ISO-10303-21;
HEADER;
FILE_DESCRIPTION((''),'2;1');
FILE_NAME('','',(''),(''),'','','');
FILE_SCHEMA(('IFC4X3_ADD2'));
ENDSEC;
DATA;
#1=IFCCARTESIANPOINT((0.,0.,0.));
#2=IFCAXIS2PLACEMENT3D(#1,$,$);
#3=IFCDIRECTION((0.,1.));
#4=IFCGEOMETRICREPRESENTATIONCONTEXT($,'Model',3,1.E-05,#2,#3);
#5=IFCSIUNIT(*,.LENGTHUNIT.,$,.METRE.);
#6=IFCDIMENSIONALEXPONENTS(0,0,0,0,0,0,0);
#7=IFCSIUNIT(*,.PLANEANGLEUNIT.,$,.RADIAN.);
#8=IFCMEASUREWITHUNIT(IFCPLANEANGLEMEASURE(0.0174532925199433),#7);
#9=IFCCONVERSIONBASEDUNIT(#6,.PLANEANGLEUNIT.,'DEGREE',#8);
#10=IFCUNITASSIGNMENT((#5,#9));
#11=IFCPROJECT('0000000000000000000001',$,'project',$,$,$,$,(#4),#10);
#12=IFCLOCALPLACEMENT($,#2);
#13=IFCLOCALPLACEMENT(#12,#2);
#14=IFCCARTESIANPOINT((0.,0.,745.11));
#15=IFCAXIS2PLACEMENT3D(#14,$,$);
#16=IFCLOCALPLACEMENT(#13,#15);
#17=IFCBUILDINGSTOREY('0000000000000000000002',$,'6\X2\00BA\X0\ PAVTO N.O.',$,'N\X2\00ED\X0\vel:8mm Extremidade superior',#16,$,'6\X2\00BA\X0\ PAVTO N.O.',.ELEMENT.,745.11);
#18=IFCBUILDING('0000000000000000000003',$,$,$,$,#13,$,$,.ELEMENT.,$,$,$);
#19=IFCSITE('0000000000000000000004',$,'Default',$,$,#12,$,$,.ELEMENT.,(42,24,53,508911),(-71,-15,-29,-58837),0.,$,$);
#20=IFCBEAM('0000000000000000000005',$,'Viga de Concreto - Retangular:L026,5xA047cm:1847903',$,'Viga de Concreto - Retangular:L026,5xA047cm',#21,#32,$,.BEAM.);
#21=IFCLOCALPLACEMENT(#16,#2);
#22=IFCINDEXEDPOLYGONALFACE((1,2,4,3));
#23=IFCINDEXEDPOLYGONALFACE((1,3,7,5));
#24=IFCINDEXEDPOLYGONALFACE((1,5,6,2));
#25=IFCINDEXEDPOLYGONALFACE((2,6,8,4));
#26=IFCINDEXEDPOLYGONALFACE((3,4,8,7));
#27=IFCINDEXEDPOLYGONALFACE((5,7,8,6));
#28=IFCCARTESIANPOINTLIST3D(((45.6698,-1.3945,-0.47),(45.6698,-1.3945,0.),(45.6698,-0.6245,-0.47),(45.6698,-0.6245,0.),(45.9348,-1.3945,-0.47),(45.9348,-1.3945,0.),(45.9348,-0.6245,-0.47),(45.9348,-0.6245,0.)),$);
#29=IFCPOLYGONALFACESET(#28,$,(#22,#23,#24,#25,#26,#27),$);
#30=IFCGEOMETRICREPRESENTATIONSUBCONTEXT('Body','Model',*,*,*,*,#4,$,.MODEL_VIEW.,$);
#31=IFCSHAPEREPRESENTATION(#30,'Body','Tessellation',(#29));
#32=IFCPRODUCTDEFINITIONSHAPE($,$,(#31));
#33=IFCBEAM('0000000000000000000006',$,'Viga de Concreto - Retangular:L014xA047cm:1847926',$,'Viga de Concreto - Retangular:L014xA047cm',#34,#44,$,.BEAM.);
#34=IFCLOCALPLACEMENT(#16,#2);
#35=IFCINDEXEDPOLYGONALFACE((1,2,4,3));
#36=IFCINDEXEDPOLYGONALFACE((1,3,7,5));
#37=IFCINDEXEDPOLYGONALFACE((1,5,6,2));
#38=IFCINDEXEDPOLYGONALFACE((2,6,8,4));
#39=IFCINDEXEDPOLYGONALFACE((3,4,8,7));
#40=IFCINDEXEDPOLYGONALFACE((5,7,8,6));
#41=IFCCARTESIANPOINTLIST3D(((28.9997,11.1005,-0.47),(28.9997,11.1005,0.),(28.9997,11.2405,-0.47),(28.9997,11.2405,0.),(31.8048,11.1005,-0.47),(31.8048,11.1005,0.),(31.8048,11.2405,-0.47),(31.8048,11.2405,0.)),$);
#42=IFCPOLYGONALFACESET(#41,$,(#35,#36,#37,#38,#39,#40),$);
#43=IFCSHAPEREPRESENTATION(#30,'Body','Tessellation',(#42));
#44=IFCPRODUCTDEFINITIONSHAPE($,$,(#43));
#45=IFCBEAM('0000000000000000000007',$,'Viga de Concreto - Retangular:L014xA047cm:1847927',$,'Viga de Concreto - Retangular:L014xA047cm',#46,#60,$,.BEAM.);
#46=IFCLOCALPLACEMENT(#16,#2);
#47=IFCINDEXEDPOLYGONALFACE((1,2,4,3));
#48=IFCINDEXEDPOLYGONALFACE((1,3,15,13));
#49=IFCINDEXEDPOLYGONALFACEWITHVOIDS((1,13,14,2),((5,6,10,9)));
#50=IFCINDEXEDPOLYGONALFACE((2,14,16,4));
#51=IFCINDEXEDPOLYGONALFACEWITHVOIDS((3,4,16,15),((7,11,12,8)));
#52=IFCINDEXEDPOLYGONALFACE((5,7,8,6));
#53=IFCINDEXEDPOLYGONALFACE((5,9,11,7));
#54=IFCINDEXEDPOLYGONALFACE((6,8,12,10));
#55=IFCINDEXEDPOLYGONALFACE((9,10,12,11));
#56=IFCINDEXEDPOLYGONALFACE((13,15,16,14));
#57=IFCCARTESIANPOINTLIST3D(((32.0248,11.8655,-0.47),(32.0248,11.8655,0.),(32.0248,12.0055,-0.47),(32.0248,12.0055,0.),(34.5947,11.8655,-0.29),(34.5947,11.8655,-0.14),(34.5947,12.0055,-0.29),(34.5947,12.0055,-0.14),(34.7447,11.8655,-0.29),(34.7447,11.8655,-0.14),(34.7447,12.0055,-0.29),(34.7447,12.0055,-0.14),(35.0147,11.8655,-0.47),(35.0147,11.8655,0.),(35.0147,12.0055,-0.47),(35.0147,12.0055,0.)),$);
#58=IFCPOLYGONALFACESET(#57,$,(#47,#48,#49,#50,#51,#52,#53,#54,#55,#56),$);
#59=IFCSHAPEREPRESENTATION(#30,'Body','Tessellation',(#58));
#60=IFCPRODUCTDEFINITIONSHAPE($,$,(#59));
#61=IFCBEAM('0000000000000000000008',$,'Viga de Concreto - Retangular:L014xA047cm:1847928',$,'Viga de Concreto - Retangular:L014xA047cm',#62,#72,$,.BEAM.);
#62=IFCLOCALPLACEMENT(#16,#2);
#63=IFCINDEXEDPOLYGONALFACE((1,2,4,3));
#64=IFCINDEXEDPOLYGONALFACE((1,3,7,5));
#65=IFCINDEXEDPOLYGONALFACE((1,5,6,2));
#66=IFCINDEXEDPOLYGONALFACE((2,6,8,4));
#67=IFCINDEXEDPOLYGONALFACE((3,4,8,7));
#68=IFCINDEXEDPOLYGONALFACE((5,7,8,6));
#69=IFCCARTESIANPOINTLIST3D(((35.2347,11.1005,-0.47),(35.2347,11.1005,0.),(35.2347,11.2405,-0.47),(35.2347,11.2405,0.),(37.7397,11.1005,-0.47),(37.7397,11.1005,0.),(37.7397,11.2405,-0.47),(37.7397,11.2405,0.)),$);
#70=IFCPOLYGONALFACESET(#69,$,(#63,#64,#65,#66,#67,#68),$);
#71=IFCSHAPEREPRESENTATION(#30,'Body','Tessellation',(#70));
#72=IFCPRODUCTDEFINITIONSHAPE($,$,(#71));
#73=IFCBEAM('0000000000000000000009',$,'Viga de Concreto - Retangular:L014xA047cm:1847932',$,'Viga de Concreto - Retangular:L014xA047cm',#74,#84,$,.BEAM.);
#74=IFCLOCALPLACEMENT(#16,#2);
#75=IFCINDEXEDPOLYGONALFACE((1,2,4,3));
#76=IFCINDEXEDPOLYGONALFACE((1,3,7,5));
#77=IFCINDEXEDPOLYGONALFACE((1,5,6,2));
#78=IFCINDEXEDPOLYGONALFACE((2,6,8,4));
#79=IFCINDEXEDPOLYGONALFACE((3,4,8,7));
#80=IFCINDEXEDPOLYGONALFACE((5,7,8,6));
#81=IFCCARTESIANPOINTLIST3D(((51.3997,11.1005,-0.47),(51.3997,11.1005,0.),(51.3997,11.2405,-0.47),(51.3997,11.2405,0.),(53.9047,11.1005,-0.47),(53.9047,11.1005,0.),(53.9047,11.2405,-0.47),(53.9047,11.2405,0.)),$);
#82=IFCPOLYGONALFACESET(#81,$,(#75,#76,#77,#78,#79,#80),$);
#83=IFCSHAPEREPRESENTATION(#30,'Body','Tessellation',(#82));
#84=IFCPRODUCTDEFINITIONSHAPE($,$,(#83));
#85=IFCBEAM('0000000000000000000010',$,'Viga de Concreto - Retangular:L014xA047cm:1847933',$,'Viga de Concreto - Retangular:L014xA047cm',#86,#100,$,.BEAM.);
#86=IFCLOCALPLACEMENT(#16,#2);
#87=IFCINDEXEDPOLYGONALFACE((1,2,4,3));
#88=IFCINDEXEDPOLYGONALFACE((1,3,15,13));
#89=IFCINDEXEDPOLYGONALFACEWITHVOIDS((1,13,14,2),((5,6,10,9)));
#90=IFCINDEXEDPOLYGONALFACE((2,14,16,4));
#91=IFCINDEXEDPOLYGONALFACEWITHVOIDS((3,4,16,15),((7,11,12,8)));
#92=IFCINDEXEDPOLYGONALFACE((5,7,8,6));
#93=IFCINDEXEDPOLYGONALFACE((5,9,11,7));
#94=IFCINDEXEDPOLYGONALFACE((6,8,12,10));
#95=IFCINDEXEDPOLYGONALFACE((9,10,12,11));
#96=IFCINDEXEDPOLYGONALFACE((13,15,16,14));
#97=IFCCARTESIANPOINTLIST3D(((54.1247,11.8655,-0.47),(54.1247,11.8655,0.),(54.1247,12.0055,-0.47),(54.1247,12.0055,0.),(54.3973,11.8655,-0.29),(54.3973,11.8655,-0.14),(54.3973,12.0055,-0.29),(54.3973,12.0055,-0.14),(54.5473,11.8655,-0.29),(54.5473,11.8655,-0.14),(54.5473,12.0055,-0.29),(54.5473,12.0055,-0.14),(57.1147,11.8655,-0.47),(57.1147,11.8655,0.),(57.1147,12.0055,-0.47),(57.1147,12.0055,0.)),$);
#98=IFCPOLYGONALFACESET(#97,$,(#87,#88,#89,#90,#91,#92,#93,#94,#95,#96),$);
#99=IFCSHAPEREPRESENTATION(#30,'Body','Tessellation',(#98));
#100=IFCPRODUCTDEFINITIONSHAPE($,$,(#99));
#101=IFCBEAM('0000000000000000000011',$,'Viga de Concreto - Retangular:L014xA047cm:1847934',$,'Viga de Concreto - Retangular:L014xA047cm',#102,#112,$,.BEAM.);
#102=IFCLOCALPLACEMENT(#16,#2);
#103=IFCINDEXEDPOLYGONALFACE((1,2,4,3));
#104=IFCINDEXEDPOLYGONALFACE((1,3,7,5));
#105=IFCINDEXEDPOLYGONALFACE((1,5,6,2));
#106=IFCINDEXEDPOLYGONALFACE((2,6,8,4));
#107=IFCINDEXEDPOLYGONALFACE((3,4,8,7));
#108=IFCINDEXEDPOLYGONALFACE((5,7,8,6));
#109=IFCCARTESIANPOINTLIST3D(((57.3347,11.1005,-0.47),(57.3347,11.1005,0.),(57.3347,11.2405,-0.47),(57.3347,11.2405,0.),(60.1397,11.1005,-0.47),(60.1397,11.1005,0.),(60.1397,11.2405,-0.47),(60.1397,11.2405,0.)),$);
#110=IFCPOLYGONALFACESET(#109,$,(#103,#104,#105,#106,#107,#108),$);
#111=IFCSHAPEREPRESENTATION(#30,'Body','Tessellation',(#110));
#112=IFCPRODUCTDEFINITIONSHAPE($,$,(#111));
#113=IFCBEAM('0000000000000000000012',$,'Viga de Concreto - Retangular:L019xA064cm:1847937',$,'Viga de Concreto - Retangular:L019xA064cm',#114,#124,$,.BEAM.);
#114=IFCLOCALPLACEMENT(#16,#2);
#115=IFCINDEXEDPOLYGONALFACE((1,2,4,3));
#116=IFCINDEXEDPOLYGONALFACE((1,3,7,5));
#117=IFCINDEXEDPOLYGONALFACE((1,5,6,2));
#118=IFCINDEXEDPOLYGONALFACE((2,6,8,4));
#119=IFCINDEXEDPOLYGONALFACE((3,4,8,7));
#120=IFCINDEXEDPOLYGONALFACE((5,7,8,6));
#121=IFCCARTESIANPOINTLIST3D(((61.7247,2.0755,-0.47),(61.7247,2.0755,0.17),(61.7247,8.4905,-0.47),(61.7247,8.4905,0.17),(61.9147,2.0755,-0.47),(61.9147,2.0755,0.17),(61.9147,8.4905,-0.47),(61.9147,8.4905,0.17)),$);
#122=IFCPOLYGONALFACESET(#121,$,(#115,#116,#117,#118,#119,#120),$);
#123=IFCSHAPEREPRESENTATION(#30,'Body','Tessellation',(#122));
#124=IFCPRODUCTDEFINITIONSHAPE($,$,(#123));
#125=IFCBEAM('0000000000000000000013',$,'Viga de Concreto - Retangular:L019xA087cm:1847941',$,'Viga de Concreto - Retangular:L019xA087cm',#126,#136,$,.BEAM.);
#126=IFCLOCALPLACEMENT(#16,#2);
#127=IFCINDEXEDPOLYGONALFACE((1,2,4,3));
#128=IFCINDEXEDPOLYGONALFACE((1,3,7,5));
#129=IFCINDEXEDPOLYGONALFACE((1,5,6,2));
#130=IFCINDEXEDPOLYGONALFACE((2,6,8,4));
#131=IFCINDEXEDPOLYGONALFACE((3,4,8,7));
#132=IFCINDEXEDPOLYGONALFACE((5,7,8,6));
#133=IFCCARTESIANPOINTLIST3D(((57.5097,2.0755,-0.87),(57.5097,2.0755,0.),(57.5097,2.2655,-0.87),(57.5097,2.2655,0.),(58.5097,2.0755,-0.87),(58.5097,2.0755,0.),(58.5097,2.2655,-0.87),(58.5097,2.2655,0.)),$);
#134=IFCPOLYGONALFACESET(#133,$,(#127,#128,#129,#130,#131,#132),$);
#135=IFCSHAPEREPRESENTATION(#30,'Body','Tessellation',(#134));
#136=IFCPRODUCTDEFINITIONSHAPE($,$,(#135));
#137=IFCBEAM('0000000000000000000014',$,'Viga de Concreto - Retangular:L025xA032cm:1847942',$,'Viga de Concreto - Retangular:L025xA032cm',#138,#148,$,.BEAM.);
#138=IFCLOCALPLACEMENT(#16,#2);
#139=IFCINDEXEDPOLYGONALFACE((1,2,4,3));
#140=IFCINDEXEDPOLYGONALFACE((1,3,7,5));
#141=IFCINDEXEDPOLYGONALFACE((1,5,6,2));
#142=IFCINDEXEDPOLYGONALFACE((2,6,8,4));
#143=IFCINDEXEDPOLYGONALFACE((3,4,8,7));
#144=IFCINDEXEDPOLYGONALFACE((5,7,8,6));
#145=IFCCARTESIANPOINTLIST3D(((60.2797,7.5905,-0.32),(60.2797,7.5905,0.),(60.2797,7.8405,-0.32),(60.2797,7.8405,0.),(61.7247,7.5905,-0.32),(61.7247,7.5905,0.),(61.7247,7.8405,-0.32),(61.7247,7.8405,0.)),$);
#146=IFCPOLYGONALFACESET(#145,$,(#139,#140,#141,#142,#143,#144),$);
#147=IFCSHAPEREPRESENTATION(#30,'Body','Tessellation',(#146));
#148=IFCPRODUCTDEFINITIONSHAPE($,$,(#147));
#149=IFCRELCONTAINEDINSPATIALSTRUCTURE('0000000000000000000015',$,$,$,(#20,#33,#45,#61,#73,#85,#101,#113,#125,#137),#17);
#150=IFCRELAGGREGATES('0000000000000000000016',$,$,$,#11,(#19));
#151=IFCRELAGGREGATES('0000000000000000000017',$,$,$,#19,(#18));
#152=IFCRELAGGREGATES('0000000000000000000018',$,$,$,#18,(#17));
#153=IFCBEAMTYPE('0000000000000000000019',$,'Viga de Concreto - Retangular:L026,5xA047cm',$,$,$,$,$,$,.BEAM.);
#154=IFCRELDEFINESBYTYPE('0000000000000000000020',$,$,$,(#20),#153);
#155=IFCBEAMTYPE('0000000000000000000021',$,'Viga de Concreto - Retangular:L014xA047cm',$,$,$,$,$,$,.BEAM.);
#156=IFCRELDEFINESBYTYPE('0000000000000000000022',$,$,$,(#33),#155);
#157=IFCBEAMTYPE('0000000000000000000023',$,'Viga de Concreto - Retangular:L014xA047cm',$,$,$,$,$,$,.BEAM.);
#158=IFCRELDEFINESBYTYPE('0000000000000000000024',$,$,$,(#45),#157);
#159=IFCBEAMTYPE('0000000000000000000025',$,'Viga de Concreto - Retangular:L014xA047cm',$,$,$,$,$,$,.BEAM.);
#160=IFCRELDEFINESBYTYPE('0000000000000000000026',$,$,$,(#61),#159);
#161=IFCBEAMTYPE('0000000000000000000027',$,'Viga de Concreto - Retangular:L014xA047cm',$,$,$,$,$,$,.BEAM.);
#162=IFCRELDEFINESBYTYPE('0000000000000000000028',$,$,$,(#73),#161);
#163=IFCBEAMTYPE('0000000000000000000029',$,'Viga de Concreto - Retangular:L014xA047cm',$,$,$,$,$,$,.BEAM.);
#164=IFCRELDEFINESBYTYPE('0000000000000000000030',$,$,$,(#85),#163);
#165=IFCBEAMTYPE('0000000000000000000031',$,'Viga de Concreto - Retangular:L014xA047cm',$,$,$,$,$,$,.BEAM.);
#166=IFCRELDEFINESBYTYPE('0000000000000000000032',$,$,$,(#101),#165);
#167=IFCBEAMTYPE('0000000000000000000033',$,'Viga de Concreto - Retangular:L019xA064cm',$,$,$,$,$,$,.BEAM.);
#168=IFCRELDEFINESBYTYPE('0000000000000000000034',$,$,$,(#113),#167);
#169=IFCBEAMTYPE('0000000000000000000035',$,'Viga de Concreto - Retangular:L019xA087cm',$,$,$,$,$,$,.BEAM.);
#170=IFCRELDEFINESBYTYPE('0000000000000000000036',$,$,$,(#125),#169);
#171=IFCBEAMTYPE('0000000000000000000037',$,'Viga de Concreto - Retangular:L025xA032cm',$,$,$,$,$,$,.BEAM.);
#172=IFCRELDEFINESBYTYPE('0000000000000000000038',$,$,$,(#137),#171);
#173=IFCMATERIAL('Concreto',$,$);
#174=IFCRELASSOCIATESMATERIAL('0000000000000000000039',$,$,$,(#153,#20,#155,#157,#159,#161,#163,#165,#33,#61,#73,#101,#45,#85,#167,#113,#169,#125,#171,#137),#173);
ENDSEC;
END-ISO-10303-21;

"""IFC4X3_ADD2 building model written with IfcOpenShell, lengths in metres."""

from ifc_helpers import new_model, entity, si_unit, converted_unit, direction, frame, frame_2d, origin, origin_2d_with_axis, place, context, subcontext, project, spatial, rectangle, extrude, boolean, source, transform, mapped, material, material_profile, profile_set, profile_usage, type_object, type_shapes, element, save


model = new_model("IFC4X3_ADD2")

# Units and contexts
model_context = context("Model", 3, precision=1e-05, world=origin(), true_north=direction((0.0, 1.0)))
body_context = subcontext(model_context, "Body", "Model", "MODEL_VIEW")
ifc_project = project(units=[si_unit("LENGTHUNIT", "METRE"), converted_unit("PLANEANGLEUNIT", "DEGREE", entity("IfcPlaneAngleMeasure", 0.0174532925199433), si_unit("PLANEANGLEUNIT", "RADIAN"), dimensions=[0, 0, 0, 0, 0, 0, 0])], contexts=[model_context])

# Site, building, storey
site_placement = place(None, origin())
site = spatial("IfcSite", under=ifc_project, at=site_placement, Name="Default", CompositionType="ELEMENT", RefLatitude=(42, 24, 53, 508911), RefLongitude=(-71, -15, -29, -58837), RefElevation=0.0)
building_placement = place(site_placement, origin())
building = spatial("IfcBuilding", under=site, at=building_placement, CompositionType="ELEMENT")
storey_placement = place(building_placement, frame((0.0, 0.0, 745.11)))
storey = spatial("IfcBuildingStorey", under=building, at=storey_placement, Name="6º PAVTO N.O.", ObjectType="Nível:8mm Extremidade superior", LongName="6º PAVTO N.O.", CompositionType="ELEMENT", Elevation=745.11)

# Beams
ifc_material = material(Name="Concreto")
ifc_material_profile_1 = material_profile(ifc_material, rectangle(XDim=0.47, YDim=0.265, at=frame_2d((0.0, 0.0), x_axis=(0.0, 1.0))), Name="L026,5xA047cm")
ifc_profile_set_1 = profile_set([ifc_material_profile_1], Name="L026,5xA047cm")
ifc_profile_usage_1 = profile_usage(ifc_profile_set_1, cardinal=8)
beam_type_1 = type_object("IfcBeamType", Name="Viga de Concreto - Retangular:L026,5xA047cm", PredefinedType="BEAM", material=ifc_profile_set_1)
shared_shape_1 = source(origin(), body_context, "Body", "SweptSolid", [
    extrude(rectangle(XDim=0.47, YDim=0.265, at=frame_2d((0.0, 0.0), x_axis=(0.0, 1.0))), frame((45.8023, -0.6245, 744.875), z_axis=(0.0, -1.0, 0.0), x_axis=(-1.0, 0.0, 0.0)), (0.0, 0.0, 1.0), 0.77),
])
type_shapes(beam_type_1, [shared_shape_1])
beam_1_placement = place(storey_placement, frame((0.0, 0.0, -745.11)))
element("IfcBeam", 1, at=beam_1_placement, inside=storey, type_object=beam_type_1, material=ifc_profile_usage_1, Name="Viga de Concreto - Retangular:L026,5xA047cm:1847903", ObjectType="Viga de Concreto - Retangular:L026,5xA047cm", PredefinedType="BEAM", context=body_context, shape_type="MappedRepresentation", body=[
    mapped(shared_shape_1, transform((0.0, 0.0, 0.0), scale=1.0)),
])
ifc_material_profile_2 = material_profile(ifc_material, rectangle(XDim=0.47, YDim=0.14, at=frame_2d((0.0, 0.0), x_axis=(0.0, 1.0))), Name="L014xA047cm")
ifc_profile_set_2 = profile_set([ifc_material_profile_2], Name="L014xA047cm")
ifc_profile_usage_2 = profile_usage(ifc_profile_set_2, cardinal=8)
beam_type_2 = type_object("IfcBeamType", Name="Viga de Concreto - Retangular:L014xA047cm", PredefinedType="BEAM", material=ifc_profile_set_2)
shared_shape_2 = source(origin(), body_context, "Body", "SweptSolid", [
    extrude(rectangle(XDim=0.47, YDim=0.14, at=origin_2d_with_axis()), frame((31.8048, 11.1705, 744.875), z_axis=(-1.0, 0.0, 0.0), x_axis=(0.0, 0.0, -1.0)), (0.0, 0.0, 1.0), 2.8051),
])
type_shapes(beam_type_2, [shared_shape_2])
beam_2_placement = place(storey_placement, frame((0.0, 0.0, -745.11)))
element("IfcBeam", 2, at=beam_2_placement, inside=storey, type_object=beam_type_2, material=ifc_profile_usage_2, Name="Viga de Concreto - Retangular:L014xA047cm:1847926", ObjectType="Viga de Concreto - Retangular:L014xA047cm", PredefinedType="BEAM", context=body_context, shape_type="MappedRepresentation", body=[
    mapped(shared_shape_2, transform((0.0, 0.0, 0.0), scale=1.0)),
])
beam_type_3 = type_object("IfcBeamType", Name="Viga de Concreto - Retangular:L014xA047cm", PredefinedType="BEAM", material=ifc_profile_set_2)
shared_shape_3 = source(origin(), body_context, "Body", "CSG", [
    boolean("DIFFERENCE", extrude(rectangle(XDim=0.47, YDim=0.14, at=frame_2d((0.0, 0.0), x_axis=(0.0, 1.0))), frame((32.0248, 11.9355, 744.875), z_axis=(1.0, 0.0, 0.0), x_axis=(0.0, 1.0, 0.0)), (0.0, 0.0, 1.0), 2.9899), extrude(rectangle(XDim=0.15, YDim=0.15, at=frame_2d((0.0, 0.0), x_axis=(0.0, 1.0))), frame((34.6697, 11.8655, 744.895), z_axis=(0.0, 1.0, 0.0), x_axis=(1.0, 0.0, 0.0)), (0.0, 0.0, 1.0), 0.14)),
])
type_shapes(beam_type_3, [shared_shape_3])
beam_3_placement = place(storey_placement, frame((0.0, 0.0, -745.11)))
element("IfcBeam", 3, at=beam_3_placement, inside=storey, type_object=beam_type_3, material=ifc_material, Name="Viga de Concreto - Retangular:L014xA047cm:1847927", ObjectType="Viga de Concreto - Retangular:L014xA047cm", PredefinedType="BEAM", context=body_context, shape_type="MappedRepresentation", body=[
    mapped(shared_shape_3, transform((0.0, 0.0, 0.0), scale=1.0)),
])
beam_type_4 = type_object("IfcBeamType", Name="Viga de Concreto - Retangular:L014xA047cm", PredefinedType="BEAM", material=ifc_profile_set_2)
shared_shape_4 = source(origin(), body_context, "Body", "SweptSolid", [
    extrude(rectangle(XDim=0.47, YDim=0.14, at=origin_2d_with_axis()), frame((35.2347, 11.1705, 744.875), z_axis=(1.0, 0.0, 0.0), x_axis=(0.0, 0.0, -1.0)), (0.0, 0.0, 1.0), 2.505),
])
type_shapes(beam_type_4, [shared_shape_4])
beam_4_placement = place(storey_placement, frame((0.0, 0.0, -745.11)))
element("IfcBeam", 4, at=beam_4_placement, inside=storey, type_object=beam_type_4, material=ifc_profile_usage_2, Name="Viga de Concreto - Retangular:L014xA047cm:1847928", ObjectType="Viga de Concreto - Retangular:L014xA047cm", PredefinedType="BEAM", context=body_context, shape_type="MappedRepresentation", body=[
    mapped(shared_shape_4, transform((0.0, 0.0, 0.0), scale=1.0)),
])
beam_type_5 = type_object("IfcBeamType", Name="Viga de Concreto - Retangular:L014xA047cm", PredefinedType="BEAM", material=ifc_profile_set_2)
shared_shape_5 = source(origin(), body_context, "Body", "SweptSolid", [
    extrude(rectangle(XDim=0.47, YDim=0.14, at=origin_2d_with_axis()), frame((51.3997, 11.1705, 744.875), z_axis=(1.0, 0.0, 0.0), x_axis=(0.0, 0.0, -1.0)), (0.0, 0.0, 1.0), 2.505),
])
type_shapes(beam_type_5, [shared_shape_5])
beam_5_placement = place(storey_placement, frame((0.0, 0.0, -745.11)))
element("IfcBeam", 5, at=beam_5_placement, inside=storey, type_object=beam_type_5, material=ifc_profile_usage_2, Name="Viga de Concreto - Retangular:L014xA047cm:1847932", ObjectType="Viga de Concreto - Retangular:L014xA047cm", PredefinedType="BEAM", context=body_context, shape_type="MappedRepresentation", body=[
    mapped(shared_shape_5, transform((0.0, 0.0, 0.0), scale=1.0)),
])
beam_type_6 = type_object("IfcBeamType", Name="Viga de Concreto - Retangular:L014xA047cm", PredefinedType="BEAM", material=ifc_profile_set_2)
shared_shape_6 = source(origin(), body_context, "Body", "CSG", [
    boolean("DIFFERENCE", extrude(rectangle(XDim=0.47, YDim=0.14, at=frame_2d((0.0, 0.0), x_axis=(0.0, 1.0))), frame((54.1247, 11.9355, 744.875), z_axis=(1.0, 0.0, 0.0), x_axis=(0.0, 1.0, 0.0)), (0.0, 0.0, 1.0), 2.99), extrude(rectangle(XDim=0.15, YDim=0.15, at=frame_2d((0.0, 0.0), x_axis=(0.0, 1.0))), frame((54.4723, 11.8655, 744.895), z_axis=(0.0, 1.0, 0.0), x_axis=(1.0, 0.0, 0.0)), (0.0, 0.0, 1.0), 0.14)),
])
type_shapes(beam_type_6, [shared_shape_6])
beam_6_placement = place(storey_placement, frame((0.0, 0.0, -745.11)))
element("IfcBeam", 6, at=beam_6_placement, inside=storey, type_object=beam_type_6, material=ifc_material, Name="Viga de Concreto - Retangular:L014xA047cm:1847933", ObjectType="Viga de Concreto - Retangular:L014xA047cm", PredefinedType="BEAM", context=body_context, shape_type="MappedRepresentation", body=[
    mapped(shared_shape_6, transform((0.0, 0.0, 0.0), scale=1.0)),
])
beam_type_7 = type_object("IfcBeamType", Name="Viga de Concreto - Retangular:L014xA047cm", PredefinedType="BEAM", material=ifc_profile_set_2)
shared_shape_7 = source(origin(), body_context, "Body", "SweptSolid", [
    extrude(rectangle(XDim=0.47, YDim=0.14, at=origin_2d_with_axis()), frame((57.3347, 11.1705, 744.875), z_axis=(1.0, 0.0, 0.0), x_axis=(0.0, 0.0, -1.0)), (0.0, 0.0, 1.0), 2.805),
])
type_shapes(beam_type_7, [shared_shape_7])
beam_7_placement = place(storey_placement, frame((0.0, 0.0, -745.11)))
element("IfcBeam", 7, at=beam_7_placement, inside=storey, type_object=beam_type_7, material=ifc_profile_usage_2, Name="Viga de Concreto - Retangular:L014xA047cm:1847934", ObjectType="Viga de Concreto - Retangular:L014xA047cm", PredefinedType="BEAM", context=body_context, shape_type="MappedRepresentation", body=[
    mapped(shared_shape_7, transform((0.0, 0.0, 0.0), scale=1.0)),
])
ifc_material_profile_3 = material_profile(ifc_material, rectangle(XDim=0.64, YDim=0.19, at=frame_2d((0.0, 0.0), x_axis=(1.0, 0.0))), Name="L019xA064cm")
ifc_profile_set_3 = profile_set([ifc_material_profile_3], Name="L019xA064cm")
ifc_profile_usage_3 = profile_usage(ifc_profile_set_3, cardinal=8)
beam_type_8 = type_object("IfcBeamType", Name="Viga de Concreto - Retangular:L019xA064cm", PredefinedType="BEAM", material=ifc_profile_set_3)
shared_shape_8 = source(origin(), body_context, "Body", "SweptSolid", [
    extrude(rectangle(XDim=0.64, YDim=0.19, at=frame_2d((0.0, 0.0), x_axis=(0.0, 1.0))), frame((61.8197, 8.4905, 744.96), z_axis=(0.0, -1.0, 0.0), x_axis=(-1.0, 0.0, 0.0)), (0.0, 0.0, 1.0), 6.415),
])
type_shapes(beam_type_8, [shared_shape_8])
beam_8_placement = place(storey_placement, frame((0.0, 0.0, -745.11)))
element("IfcBeam", 8, at=beam_8_placement, inside=storey, type_object=beam_type_8, material=ifc_profile_usage_3, Name="Viga de Concreto - Retangular:L019xA064cm:1847937", ObjectType="Viga de Concreto - Retangular:L019xA064cm", PredefinedType="BEAM", context=body_context, shape_type="MappedRepresentation", body=[
    mapped(shared_shape_8, transform((0.0, 0.0, 0.0), scale=1.0)),
])
ifc_material_profile_4 = material_profile(ifc_material, rectangle(XDim=0.87, YDim=0.19, at=origin_2d_with_axis()), Name="L019xA087cm")
ifc_profile_set_4 = profile_set([ifc_material_profile_4], Name="L019xA087cm")
ifc_profile_usage_4 = profile_usage(ifc_profile_set_4, cardinal=8)
beam_type_9 = type_object("IfcBeamType", Name="Viga de Concreto - Retangular:L019xA087cm", PredefinedType="BEAM", material=ifc_profile_set_4)
shared_shape_9 = source(origin(), body_context, "Body", "SweptSolid", [
    extrude(rectangle(XDim=0.87, YDim=0.19, at=origin_2d_with_axis()), frame((57.5097, 2.1705, 744.675), z_axis=(1.0, 0.0, 0.0), x_axis=(0.0, 0.0, -1.0)), (0.0, 0.0, 1.0), 1.0),
])
type_shapes(beam_type_9, [shared_shape_9])
beam_9_placement = place(storey_placement, frame((0.0, 0.0, -745.11)))
element("IfcBeam", 9, at=beam_9_placement, inside=storey, type_object=beam_type_9, material=ifc_profile_usage_4, Name="Viga de Concreto - Retangular:L019xA087cm:1847941", ObjectType="Viga de Concreto - Retangular:L019xA087cm", PredefinedType="BEAM", context=body_context, shape_type="MappedRepresentation", body=[
    mapped(shared_shape_9, transform((0.0, 0.0, 0.0), scale=1.0)),
])
ifc_material_profile_5 = material_profile(ifc_material, rectangle(XDim=0.32, YDim=0.25, at=frame_2d((0.0, 0.0), x_axis=(1.0, 0.0))), Name="L025xA032cm")
ifc_profile_set_5 = profile_set([ifc_material_profile_5], Name="L025xA032cm")
ifc_profile_usage_5 = profile_usage(ifc_profile_set_5, cardinal=8)
beam_type_10 = type_object("IfcBeamType", Name="Viga de Concreto - Retangular:L025xA032cm", PredefinedType="BEAM", material=ifc_profile_set_5)
shared_shape_10 = source(origin(), body_context, "Body", "SweptSolid", [
    extrude(rectangle(XDim=0.32, YDim=0.25, at=frame_2d((0.0, 0.0), x_axis=(1.0, 0.0))), frame((60.2797, 7.7155, 744.95), z_axis=(1.0, 0.0, 0.0), x_axis=(0.0, 0.0, -1.0)), (0.0, 0.0, 1.0), 1.445),
])
type_shapes(beam_type_10, [shared_shape_10])
beam_10_placement = place(storey_placement, frame((0.0, 0.0, -745.11)))
element("IfcBeam", 10, at=beam_10_placement, inside=storey, type_object=beam_type_10, material=ifc_profile_usage_5, Name="Viga de Concreto - Retangular:L025xA032cm:1847942", ObjectType="Viga de Concreto - Retangular:L025xA032cm", PredefinedType="BEAM", context=body_context, shape_type="MappedRepresentation", body=[
    mapped(shared_shape_10, transform((0.0, 0.0, 0.0), scale=1.0)),
])

save(model, "model.ifc")
